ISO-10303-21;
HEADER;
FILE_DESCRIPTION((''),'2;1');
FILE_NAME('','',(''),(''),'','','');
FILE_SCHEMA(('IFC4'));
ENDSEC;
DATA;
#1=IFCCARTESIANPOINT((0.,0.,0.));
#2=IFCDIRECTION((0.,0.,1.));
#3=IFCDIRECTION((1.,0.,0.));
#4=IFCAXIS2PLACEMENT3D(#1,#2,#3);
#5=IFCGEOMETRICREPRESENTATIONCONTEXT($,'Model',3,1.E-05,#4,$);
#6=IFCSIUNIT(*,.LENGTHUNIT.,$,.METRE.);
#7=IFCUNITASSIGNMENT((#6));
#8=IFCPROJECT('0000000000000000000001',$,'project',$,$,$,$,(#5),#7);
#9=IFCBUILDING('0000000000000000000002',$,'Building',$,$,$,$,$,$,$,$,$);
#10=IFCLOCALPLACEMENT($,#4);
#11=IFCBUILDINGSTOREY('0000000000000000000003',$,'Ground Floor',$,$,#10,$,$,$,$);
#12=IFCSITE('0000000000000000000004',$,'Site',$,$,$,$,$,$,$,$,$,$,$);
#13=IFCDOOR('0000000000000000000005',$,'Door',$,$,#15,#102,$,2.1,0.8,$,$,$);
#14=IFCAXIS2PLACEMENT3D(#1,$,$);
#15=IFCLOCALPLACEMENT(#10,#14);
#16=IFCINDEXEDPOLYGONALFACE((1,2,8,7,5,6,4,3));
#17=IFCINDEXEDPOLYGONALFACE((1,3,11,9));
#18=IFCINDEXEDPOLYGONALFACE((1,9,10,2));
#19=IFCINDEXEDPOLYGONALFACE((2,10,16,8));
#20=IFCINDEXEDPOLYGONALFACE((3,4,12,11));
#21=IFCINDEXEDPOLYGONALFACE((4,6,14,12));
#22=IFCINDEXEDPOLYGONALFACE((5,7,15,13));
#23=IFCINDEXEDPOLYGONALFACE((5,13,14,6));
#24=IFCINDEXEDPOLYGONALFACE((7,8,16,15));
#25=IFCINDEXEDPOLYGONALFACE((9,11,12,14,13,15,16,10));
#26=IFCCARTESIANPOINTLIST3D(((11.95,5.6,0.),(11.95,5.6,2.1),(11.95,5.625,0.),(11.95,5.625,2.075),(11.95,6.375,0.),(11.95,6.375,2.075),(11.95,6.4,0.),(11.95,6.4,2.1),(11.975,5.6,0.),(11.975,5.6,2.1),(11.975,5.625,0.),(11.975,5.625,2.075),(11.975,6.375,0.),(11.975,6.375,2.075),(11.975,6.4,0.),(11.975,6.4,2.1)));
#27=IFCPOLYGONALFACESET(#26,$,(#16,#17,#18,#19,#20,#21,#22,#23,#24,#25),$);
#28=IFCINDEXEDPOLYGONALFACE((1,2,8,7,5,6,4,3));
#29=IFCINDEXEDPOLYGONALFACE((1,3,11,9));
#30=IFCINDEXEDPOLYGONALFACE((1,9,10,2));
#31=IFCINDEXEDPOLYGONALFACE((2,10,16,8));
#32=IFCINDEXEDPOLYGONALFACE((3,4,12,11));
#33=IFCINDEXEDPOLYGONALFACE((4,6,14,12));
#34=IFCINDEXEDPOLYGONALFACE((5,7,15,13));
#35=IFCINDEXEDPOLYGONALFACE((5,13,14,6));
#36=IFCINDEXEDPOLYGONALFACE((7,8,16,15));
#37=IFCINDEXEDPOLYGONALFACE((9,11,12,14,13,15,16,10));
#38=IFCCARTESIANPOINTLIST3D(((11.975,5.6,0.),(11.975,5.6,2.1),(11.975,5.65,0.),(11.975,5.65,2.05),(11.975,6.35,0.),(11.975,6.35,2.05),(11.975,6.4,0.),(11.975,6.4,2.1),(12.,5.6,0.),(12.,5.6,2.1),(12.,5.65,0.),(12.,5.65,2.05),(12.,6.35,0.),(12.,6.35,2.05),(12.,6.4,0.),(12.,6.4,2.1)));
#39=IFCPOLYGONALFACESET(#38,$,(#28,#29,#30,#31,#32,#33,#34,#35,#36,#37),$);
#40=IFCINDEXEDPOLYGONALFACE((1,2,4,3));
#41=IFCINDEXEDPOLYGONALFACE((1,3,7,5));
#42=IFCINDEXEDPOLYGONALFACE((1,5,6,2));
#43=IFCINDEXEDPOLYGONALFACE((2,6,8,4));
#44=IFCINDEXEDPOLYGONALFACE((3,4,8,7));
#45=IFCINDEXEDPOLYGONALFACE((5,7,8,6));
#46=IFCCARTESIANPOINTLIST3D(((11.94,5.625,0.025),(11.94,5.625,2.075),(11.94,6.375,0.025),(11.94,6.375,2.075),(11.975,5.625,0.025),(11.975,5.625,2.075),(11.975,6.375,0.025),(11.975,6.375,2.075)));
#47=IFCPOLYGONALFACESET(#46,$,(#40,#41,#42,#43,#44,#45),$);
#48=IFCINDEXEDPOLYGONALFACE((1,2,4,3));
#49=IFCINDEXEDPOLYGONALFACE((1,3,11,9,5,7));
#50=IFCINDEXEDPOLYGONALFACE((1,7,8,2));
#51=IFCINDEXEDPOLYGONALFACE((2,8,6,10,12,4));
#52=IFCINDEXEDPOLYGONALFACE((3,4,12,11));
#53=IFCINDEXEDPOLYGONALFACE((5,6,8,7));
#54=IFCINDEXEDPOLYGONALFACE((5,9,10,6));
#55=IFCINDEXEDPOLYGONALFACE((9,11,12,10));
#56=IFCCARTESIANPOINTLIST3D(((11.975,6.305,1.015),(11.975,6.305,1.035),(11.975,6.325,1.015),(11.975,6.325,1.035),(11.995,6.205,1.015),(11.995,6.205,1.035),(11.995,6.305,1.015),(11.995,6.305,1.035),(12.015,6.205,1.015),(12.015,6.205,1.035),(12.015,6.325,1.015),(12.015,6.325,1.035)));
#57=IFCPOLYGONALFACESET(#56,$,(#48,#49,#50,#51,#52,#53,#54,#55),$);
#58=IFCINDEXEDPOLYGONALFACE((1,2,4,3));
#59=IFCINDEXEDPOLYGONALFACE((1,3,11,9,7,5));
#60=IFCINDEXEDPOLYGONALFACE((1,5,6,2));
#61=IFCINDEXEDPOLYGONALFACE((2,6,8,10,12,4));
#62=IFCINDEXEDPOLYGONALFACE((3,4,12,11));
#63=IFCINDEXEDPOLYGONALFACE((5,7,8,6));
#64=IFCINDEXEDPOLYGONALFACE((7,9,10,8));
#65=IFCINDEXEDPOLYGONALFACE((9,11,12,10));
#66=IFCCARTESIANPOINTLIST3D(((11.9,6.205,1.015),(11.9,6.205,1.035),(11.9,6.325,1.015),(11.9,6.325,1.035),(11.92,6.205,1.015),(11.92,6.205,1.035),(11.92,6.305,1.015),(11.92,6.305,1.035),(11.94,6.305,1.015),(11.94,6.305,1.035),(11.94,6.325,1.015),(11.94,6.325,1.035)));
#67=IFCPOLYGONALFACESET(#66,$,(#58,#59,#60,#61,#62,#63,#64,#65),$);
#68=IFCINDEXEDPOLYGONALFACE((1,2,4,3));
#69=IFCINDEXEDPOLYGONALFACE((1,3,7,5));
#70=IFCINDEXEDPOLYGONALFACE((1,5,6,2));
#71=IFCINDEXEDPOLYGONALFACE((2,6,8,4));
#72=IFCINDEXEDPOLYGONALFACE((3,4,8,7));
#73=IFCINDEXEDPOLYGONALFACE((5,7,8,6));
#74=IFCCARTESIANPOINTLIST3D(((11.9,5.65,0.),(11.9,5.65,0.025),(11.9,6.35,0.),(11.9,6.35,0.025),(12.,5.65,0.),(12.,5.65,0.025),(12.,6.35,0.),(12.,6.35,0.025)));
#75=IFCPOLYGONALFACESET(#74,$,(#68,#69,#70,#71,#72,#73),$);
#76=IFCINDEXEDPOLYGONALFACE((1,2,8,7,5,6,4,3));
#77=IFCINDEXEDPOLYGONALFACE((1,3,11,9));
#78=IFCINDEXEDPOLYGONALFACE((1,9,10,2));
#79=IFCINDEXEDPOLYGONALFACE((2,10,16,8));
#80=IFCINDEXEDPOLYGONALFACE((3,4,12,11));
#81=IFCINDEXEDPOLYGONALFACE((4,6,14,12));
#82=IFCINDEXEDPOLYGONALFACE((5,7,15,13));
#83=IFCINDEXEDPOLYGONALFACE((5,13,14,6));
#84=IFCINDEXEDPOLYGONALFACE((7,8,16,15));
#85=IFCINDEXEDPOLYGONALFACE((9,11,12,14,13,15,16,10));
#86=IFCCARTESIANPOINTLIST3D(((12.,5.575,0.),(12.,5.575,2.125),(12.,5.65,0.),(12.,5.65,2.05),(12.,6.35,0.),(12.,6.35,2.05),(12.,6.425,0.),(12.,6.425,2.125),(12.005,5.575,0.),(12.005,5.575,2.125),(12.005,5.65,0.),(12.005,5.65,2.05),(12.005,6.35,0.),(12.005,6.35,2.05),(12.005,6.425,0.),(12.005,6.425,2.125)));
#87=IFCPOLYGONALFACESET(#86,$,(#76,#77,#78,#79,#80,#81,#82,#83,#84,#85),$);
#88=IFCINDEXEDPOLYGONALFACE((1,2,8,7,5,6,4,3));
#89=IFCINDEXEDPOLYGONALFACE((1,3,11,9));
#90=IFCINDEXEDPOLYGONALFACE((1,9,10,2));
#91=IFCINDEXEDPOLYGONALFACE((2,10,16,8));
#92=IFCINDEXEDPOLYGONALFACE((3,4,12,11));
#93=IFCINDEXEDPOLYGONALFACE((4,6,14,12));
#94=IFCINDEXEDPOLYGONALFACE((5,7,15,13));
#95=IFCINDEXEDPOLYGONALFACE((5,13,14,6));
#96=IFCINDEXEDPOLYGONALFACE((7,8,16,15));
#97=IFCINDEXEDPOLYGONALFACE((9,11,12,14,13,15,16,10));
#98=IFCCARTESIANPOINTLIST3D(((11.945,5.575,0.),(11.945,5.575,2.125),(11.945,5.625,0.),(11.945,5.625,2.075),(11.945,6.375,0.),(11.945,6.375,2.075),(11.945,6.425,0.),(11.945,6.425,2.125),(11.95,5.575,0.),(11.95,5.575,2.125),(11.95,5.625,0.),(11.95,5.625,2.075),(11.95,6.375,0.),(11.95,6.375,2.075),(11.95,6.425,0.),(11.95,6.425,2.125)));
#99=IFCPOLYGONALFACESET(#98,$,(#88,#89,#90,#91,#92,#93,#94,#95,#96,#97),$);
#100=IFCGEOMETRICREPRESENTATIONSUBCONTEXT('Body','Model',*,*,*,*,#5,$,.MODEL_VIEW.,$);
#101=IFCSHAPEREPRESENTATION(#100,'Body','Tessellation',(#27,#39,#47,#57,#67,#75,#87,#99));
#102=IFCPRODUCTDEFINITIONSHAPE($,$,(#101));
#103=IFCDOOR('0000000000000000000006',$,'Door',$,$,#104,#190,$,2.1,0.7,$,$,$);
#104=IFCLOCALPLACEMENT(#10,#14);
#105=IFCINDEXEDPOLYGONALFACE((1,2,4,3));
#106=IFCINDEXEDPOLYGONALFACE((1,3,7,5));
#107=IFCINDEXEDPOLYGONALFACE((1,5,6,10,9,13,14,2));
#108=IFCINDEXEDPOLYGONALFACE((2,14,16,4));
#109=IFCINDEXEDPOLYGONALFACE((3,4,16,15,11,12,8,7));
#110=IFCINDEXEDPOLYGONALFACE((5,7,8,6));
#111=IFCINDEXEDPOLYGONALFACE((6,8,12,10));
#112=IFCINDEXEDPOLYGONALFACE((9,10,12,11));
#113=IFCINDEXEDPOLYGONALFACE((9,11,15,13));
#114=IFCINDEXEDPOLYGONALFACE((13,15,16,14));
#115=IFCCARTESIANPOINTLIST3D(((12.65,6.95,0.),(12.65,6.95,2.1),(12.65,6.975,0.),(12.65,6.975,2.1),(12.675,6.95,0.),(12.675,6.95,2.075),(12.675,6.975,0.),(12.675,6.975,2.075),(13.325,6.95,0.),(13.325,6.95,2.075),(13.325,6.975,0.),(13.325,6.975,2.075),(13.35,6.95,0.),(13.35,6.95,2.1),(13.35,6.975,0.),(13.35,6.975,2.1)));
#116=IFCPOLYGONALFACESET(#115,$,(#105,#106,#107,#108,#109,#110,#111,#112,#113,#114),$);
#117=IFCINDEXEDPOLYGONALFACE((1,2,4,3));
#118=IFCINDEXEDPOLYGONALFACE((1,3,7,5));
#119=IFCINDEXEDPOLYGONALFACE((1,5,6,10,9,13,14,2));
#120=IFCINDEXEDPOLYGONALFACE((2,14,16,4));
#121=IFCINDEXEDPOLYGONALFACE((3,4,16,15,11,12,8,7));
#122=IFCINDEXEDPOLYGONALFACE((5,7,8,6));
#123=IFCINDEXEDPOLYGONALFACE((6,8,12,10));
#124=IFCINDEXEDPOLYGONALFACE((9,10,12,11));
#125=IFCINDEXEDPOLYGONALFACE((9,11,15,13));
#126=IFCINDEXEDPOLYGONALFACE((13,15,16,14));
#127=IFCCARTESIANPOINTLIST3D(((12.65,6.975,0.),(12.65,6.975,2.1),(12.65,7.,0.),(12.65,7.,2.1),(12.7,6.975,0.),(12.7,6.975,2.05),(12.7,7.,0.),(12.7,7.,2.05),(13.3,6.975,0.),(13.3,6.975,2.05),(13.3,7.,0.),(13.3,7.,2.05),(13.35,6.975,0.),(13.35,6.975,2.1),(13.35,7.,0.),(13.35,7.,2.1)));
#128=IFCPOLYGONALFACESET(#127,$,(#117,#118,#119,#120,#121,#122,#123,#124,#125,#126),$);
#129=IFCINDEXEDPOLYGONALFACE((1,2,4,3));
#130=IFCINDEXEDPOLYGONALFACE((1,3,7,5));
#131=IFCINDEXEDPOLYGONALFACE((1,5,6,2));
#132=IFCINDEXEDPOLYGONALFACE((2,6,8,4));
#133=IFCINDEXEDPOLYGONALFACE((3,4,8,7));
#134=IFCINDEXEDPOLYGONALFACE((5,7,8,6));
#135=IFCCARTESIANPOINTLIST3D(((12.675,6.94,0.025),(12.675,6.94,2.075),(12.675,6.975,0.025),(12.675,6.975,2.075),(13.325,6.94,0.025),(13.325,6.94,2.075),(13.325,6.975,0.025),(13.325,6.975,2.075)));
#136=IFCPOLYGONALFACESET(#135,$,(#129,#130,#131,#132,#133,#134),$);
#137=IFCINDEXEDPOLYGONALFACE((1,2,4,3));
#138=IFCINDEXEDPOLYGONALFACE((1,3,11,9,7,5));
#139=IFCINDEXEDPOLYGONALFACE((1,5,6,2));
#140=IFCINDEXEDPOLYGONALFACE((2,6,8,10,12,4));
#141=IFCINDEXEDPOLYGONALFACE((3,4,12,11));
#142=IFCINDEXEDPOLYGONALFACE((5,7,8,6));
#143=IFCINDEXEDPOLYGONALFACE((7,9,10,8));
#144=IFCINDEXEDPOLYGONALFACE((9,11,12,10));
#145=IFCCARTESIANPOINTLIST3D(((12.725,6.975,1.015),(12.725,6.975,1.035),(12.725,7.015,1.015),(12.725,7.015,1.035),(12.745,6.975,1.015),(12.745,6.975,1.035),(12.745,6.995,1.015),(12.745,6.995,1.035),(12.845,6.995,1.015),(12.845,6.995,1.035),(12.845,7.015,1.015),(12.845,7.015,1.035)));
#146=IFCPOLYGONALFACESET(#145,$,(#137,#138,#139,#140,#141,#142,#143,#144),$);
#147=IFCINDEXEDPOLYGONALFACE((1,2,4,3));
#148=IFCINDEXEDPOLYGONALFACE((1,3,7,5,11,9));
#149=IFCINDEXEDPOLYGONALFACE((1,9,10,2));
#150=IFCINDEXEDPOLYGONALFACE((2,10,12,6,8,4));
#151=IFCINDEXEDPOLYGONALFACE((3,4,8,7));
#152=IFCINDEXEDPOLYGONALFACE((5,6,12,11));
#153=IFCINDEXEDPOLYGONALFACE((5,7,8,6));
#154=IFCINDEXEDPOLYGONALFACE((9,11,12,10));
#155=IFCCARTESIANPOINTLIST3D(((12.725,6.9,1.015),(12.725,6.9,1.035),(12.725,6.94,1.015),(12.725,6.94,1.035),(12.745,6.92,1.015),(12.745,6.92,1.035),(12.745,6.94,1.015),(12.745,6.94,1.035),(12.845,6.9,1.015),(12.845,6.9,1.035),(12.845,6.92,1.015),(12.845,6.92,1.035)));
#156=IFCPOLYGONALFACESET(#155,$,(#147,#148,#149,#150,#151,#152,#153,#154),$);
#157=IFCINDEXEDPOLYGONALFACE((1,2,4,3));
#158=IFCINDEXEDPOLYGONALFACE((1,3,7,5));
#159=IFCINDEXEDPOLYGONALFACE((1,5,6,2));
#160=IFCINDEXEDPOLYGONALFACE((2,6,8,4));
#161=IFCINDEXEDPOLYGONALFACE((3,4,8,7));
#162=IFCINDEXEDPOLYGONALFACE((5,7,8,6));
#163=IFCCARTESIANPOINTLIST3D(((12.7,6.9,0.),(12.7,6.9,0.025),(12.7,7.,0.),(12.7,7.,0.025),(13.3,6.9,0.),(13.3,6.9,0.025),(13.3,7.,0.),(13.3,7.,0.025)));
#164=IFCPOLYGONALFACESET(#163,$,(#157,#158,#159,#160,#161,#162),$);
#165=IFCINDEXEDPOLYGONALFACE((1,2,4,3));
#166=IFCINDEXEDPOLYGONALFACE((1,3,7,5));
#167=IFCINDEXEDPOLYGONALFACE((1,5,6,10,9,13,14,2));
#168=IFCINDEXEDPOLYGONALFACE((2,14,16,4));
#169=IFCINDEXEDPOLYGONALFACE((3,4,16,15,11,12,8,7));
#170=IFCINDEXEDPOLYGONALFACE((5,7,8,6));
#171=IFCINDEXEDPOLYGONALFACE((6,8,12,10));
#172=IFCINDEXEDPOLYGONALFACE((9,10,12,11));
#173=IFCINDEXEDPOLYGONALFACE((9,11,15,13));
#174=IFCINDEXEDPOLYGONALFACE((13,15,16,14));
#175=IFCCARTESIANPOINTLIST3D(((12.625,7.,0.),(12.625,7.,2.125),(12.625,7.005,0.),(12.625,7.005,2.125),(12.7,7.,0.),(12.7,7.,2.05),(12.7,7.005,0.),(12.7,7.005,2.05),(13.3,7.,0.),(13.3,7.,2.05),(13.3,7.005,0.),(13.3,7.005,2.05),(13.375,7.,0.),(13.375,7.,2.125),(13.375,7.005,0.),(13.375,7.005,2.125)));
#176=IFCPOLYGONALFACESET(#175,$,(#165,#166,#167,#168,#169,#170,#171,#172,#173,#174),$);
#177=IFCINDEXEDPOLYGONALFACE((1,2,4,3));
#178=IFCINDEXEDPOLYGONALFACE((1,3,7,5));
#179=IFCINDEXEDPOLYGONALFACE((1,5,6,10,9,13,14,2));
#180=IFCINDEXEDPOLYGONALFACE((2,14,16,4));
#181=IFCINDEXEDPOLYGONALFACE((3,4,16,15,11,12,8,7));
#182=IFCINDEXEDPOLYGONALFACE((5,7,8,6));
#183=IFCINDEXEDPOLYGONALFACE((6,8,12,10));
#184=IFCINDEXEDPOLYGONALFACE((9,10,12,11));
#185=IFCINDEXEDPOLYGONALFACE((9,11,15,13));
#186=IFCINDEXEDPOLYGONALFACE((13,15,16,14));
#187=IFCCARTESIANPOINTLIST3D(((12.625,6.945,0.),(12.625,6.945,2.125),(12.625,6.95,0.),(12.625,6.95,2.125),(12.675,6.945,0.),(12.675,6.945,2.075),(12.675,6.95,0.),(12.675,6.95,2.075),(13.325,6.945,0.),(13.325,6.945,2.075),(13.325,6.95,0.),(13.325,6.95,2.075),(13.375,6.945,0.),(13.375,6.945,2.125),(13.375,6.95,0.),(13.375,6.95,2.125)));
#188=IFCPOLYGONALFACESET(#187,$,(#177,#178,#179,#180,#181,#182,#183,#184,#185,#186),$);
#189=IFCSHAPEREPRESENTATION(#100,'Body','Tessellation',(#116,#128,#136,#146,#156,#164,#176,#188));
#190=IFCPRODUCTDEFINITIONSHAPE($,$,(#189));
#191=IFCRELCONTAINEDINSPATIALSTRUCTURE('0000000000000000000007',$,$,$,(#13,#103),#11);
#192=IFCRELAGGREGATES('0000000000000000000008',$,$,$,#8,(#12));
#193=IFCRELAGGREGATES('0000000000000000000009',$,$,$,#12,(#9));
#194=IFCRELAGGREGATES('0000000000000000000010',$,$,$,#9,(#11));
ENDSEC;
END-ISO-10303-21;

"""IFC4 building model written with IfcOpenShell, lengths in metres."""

from ifc_helpers import new_model, si_unit, frame, origin_with_axes, place, context, subcontext, project, spatial, line, indexed_curve, outline, extrude, element, save


model = new_model("IFC4")

# Units and contexts
model_context = context("Model", 3, precision=1e-05, world=origin_with_axes())
body_context = subcontext(model_context, "Body", "Model", "MODEL_VIEW")
ifc_project = project(units=[si_unit("LENGTHUNIT", "METRE")], contexts=[model_context])

# Site, building, storey
site = spatial("IfcSite", under=ifc_project, Name="Site")
building = spatial("IfcBuilding", under=site, Name="Building")
storey_placement = place(None, origin_with_axes())
storey = spatial("IfcBuildingStorey", under=building, at=storey_placement, Name="Ground Floor")

# Doors
door_1_placement = place(storey_placement, frame((12.0, 5.6, 0.0), z_axis=(0.0, 0.0, 1.0), x_axis=(0.0, 1.0, 0.0)))
element("IfcDoor", 1, at=door_1_placement, inside=storey, Name="Door", OverallHeight=2.1, OverallWidth=0.8, context=body_context, shape_type="SweptSolid", body=[
    extrude(outline(indexed_curve([(0.0, 0.0), (0.0, 2.1), (0.8, 2.1), (0.8, 0.0), (0.775, 0.0), (0.775, 2.075), (0.025, 2.075), (0.025, 0.0)], segments=[line(1, 2, 3, 4, 5, 6, 7, 8, 1)])), frame((0.0, 0.025, 0.0), z_axis=(0.0, -1.0, 0.0), x_axis=(1.0, 0.0, 0.0)), (0.0, 0.0, -1.0), 0.025),
    extrude(outline(indexed_curve([(0.0, 0.0), (0.0, 2.1), (0.8, 2.1), (0.8, 0.0), (0.75, 0.0), (0.75, 2.05), (0.05, 2.05), (0.05, 0.0)], segments=[line(1, 2, 3, 4, 5, 6, 7, 8, 1)])), frame((0.0, 0.0, 0.0), z_axis=(0.0, -1.0, 0.0), x_axis=(1.0, 0.0, 0.0)), (0.0, 0.0, -1.0), 0.025),
    extrude(outline(indexed_curve([(0.0, 0.0), (0.75, 0.0), (0.75, 0.035), (0.0, 0.035)], segments=[line(1, 2, 3, 4, 1)])), frame((0.025, 0.025, 0.025), z_axis=(0.0, 0.0, 1.0), x_axis=(1.0, 0.0, 0.0)), (0.0, 0.0, 1.0), 2.05),
    extrude(outline(indexed_curve([(0.0, 0.0), (0.0, -0.04), (-0.12, -0.04), (-0.12, -0.02), (-0.02, -0.02), (-0.02, 0.0)], segments=[line(1, 2, 3, 4, 5, 6, 1)])), frame((0.725, 0.025, 1.015), z_axis=(0.0, 0.0, 1.0), x_axis=(1.0, 0.0, 0.0)), (0.0, 0.0, 1.0), 0.02),
    extrude(outline(indexed_curve([(0.0, 0.0), (0.0, 0.04), (-0.12, 0.04), (-0.12, 0.02), (-0.02, 0.02), (-0.02, 0.0)], segments=[line(1, 2, 3, 4, 5, 6, 1)])), frame((0.725, 0.06, 1.015), z_axis=(0.0, 0.0, 1.0), x_axis=(1.0, 0.0, 0.0)), (0.0, 0.0, 1.0), 0.02),
    extrude(outline(indexed_curve([(0.0, 0.0), (0.7, 0.0), (0.7, 0.1), (0.0, 0.1)], segments=[line(1, 2, 3, 4, 1)])), frame((0.05, 0.0, 0.0), z_axis=(0.0, 0.0, 1.0), x_axis=(1.0, 0.0, 0.0)), (0.0, 0.0, 1.0), 0.025),
    extrude(outline(indexed_curve([(0.0, 0.0), (0.0, 2.125), (0.85, 2.125), (0.85, 0.0), (0.775, 0.0), (0.775, 2.05), (0.075, 2.05), (0.075, 0.0)], segments=[line(1, 2, 3, 4, 5, 6, 7, 8, 1)])), frame((-0.025, -0.005, 0.0), z_axis=(0.0, -1.0, 0.0), x_axis=(1.0, 0.0, 0.0)), (0.0, 0.0, -1.0), 0.005),
    extrude(outline(indexed_curve([(0.0, 0.0), (0.0, 2.125), (0.85, 2.125), (0.85, 0.0), (0.8, 0.0), (0.8, 2.075), (0.05, 2.075), (0.05, 0.0)], segments=[line(1, 2, 3, 4, 5, 6, 7, 8, 1)])), frame((-0.025, 0.05, 0.0), z_axis=(0.0, -1.0, 0.0), x_axis=(1.0, 0.0, 0.0)), (0.0, 0.0, -1.0), 0.005),
])
door_2_placement = place(storey_placement, frame((13.35, 7.0, 0.0), z_axis=(0.0, 0.0, 1.0), x_axis=(-1.0, 0.0, 0.0)))
element("IfcDoor", 2, at=door_2_placement, inside=storey, Name="Door", OverallHeight=2.1, OverallWidth=0.7, context=body_context, shape_type="SweptSolid", body=[
    extrude(outline(indexed_curve([(0.0, 0.0), (0.0, 2.1), (0.7, 2.1), (0.7, 0.0), (0.675, 0.0), (0.675, 2.075), (0.025, 2.075), (0.025, 0.0)], segments=[line(1, 2, 3, 4, 5, 6, 7, 8, 1)])), frame((0.0, 0.025, 0.0), z_axis=(0.0, -1.0, 0.0), x_axis=(1.0, 0.0, 0.0)), (0.0, 0.0, -1.0), 0.025),
    extrude(outline(indexed_curve([(0.0, 0.0), (0.0, 2.1), (0.7, 2.1), (0.7, 0.0), (0.65, 0.0), (0.65, 2.05), (0.05, 2.05), (0.05, 0.0)], segments=[line(1, 2, 3, 4, 5, 6, 7, 8, 1)])), frame((0.0, 0.0, 0.0), z_axis=(0.0, -1.0, 0.0), x_axis=(1.0, 0.0, 0.0)), (0.0, 0.0, -1.0), 0.025),
    extrude(outline(indexed_curve([(0.0, 0.0), (0.65, 0.0), (0.65, 0.035), (0.0, 0.035)], segments=[line(1, 2, 3, 4, 1)])), frame((0.025, 0.025, 0.025), z_axis=(0.0, 0.0, 1.0), x_axis=(1.0, 0.0, 0.0)), (0.0, 0.0, 1.0), 2.05),
    extrude(outline(indexed_curve([(0.0, 0.0), (0.0, -0.04), (-0.12, -0.04), (-0.12, -0.02), (-0.02, -0.02), (-0.02, 0.0)], segments=[line(1, 2, 3, 4, 5, 6, 1)])), frame((0.625, 0.025, 1.015), z_axis=(0.0, 0.0, 1.0), x_axis=(1.0, 0.0, 0.0)), (0.0, 0.0, 1.0), 0.02),
    extrude(outline(indexed_curve([(0.0, 0.0), (0.0, 0.04), (-0.12, 0.04), (-0.12, 0.02), (-0.02, 0.02), (-0.02, 0.0)], segments=[line(1, 2, 3, 4, 5, 6, 1)])), frame((0.625, 0.06, 1.015), z_axis=(0.0, 0.0, 1.0), x_axis=(1.0, 0.0, 0.0)), (0.0, 0.0, 1.0), 0.02),
    extrude(outline(indexed_curve([(0.0, 0.0), (0.6, 0.0), (0.6, 0.1), (0.0, 0.1)], segments=[line(1, 2, 3, 4, 1)])), frame((0.05, 0.0, 0.0), z_axis=(0.0, 0.0, 1.0), x_axis=(1.0, 0.0, 0.0)), (0.0, 0.0, 1.0), 0.025),
    extrude(outline(indexed_curve([(0.0, 0.0), (0.0, 2.125), (0.75, 2.125), (0.75, 0.0), (0.675, 0.0), (0.675, 2.05), (0.075, 2.05), (0.075, 0.0)], segments=[line(1, 2, 3, 4, 5, 6, 7, 8, 1)])), frame((-0.025, -0.005, 0.0), z_axis=(0.0, -1.0, 0.0), x_axis=(1.0, 0.0, 0.0)), (0.0, 0.0, -1.0), 0.005),
    extrude(outline(indexed_curve([(0.0, 0.0), (0.0, 2.125), (0.75, 2.125), (0.75, 0.0), (0.7, 0.0), (0.7, 2.075), (0.05, 2.075), (0.05, 0.0)], segments=[line(1, 2, 3, 4, 5, 6, 7, 8, 1)])), frame((-0.025, 0.05, 0.0), z_axis=(0.0, -1.0, 0.0), x_axis=(1.0, 0.0, 0.0)), (0.0, 0.0, -1.0), 0.005),
])

save(model, "model.ifc")
